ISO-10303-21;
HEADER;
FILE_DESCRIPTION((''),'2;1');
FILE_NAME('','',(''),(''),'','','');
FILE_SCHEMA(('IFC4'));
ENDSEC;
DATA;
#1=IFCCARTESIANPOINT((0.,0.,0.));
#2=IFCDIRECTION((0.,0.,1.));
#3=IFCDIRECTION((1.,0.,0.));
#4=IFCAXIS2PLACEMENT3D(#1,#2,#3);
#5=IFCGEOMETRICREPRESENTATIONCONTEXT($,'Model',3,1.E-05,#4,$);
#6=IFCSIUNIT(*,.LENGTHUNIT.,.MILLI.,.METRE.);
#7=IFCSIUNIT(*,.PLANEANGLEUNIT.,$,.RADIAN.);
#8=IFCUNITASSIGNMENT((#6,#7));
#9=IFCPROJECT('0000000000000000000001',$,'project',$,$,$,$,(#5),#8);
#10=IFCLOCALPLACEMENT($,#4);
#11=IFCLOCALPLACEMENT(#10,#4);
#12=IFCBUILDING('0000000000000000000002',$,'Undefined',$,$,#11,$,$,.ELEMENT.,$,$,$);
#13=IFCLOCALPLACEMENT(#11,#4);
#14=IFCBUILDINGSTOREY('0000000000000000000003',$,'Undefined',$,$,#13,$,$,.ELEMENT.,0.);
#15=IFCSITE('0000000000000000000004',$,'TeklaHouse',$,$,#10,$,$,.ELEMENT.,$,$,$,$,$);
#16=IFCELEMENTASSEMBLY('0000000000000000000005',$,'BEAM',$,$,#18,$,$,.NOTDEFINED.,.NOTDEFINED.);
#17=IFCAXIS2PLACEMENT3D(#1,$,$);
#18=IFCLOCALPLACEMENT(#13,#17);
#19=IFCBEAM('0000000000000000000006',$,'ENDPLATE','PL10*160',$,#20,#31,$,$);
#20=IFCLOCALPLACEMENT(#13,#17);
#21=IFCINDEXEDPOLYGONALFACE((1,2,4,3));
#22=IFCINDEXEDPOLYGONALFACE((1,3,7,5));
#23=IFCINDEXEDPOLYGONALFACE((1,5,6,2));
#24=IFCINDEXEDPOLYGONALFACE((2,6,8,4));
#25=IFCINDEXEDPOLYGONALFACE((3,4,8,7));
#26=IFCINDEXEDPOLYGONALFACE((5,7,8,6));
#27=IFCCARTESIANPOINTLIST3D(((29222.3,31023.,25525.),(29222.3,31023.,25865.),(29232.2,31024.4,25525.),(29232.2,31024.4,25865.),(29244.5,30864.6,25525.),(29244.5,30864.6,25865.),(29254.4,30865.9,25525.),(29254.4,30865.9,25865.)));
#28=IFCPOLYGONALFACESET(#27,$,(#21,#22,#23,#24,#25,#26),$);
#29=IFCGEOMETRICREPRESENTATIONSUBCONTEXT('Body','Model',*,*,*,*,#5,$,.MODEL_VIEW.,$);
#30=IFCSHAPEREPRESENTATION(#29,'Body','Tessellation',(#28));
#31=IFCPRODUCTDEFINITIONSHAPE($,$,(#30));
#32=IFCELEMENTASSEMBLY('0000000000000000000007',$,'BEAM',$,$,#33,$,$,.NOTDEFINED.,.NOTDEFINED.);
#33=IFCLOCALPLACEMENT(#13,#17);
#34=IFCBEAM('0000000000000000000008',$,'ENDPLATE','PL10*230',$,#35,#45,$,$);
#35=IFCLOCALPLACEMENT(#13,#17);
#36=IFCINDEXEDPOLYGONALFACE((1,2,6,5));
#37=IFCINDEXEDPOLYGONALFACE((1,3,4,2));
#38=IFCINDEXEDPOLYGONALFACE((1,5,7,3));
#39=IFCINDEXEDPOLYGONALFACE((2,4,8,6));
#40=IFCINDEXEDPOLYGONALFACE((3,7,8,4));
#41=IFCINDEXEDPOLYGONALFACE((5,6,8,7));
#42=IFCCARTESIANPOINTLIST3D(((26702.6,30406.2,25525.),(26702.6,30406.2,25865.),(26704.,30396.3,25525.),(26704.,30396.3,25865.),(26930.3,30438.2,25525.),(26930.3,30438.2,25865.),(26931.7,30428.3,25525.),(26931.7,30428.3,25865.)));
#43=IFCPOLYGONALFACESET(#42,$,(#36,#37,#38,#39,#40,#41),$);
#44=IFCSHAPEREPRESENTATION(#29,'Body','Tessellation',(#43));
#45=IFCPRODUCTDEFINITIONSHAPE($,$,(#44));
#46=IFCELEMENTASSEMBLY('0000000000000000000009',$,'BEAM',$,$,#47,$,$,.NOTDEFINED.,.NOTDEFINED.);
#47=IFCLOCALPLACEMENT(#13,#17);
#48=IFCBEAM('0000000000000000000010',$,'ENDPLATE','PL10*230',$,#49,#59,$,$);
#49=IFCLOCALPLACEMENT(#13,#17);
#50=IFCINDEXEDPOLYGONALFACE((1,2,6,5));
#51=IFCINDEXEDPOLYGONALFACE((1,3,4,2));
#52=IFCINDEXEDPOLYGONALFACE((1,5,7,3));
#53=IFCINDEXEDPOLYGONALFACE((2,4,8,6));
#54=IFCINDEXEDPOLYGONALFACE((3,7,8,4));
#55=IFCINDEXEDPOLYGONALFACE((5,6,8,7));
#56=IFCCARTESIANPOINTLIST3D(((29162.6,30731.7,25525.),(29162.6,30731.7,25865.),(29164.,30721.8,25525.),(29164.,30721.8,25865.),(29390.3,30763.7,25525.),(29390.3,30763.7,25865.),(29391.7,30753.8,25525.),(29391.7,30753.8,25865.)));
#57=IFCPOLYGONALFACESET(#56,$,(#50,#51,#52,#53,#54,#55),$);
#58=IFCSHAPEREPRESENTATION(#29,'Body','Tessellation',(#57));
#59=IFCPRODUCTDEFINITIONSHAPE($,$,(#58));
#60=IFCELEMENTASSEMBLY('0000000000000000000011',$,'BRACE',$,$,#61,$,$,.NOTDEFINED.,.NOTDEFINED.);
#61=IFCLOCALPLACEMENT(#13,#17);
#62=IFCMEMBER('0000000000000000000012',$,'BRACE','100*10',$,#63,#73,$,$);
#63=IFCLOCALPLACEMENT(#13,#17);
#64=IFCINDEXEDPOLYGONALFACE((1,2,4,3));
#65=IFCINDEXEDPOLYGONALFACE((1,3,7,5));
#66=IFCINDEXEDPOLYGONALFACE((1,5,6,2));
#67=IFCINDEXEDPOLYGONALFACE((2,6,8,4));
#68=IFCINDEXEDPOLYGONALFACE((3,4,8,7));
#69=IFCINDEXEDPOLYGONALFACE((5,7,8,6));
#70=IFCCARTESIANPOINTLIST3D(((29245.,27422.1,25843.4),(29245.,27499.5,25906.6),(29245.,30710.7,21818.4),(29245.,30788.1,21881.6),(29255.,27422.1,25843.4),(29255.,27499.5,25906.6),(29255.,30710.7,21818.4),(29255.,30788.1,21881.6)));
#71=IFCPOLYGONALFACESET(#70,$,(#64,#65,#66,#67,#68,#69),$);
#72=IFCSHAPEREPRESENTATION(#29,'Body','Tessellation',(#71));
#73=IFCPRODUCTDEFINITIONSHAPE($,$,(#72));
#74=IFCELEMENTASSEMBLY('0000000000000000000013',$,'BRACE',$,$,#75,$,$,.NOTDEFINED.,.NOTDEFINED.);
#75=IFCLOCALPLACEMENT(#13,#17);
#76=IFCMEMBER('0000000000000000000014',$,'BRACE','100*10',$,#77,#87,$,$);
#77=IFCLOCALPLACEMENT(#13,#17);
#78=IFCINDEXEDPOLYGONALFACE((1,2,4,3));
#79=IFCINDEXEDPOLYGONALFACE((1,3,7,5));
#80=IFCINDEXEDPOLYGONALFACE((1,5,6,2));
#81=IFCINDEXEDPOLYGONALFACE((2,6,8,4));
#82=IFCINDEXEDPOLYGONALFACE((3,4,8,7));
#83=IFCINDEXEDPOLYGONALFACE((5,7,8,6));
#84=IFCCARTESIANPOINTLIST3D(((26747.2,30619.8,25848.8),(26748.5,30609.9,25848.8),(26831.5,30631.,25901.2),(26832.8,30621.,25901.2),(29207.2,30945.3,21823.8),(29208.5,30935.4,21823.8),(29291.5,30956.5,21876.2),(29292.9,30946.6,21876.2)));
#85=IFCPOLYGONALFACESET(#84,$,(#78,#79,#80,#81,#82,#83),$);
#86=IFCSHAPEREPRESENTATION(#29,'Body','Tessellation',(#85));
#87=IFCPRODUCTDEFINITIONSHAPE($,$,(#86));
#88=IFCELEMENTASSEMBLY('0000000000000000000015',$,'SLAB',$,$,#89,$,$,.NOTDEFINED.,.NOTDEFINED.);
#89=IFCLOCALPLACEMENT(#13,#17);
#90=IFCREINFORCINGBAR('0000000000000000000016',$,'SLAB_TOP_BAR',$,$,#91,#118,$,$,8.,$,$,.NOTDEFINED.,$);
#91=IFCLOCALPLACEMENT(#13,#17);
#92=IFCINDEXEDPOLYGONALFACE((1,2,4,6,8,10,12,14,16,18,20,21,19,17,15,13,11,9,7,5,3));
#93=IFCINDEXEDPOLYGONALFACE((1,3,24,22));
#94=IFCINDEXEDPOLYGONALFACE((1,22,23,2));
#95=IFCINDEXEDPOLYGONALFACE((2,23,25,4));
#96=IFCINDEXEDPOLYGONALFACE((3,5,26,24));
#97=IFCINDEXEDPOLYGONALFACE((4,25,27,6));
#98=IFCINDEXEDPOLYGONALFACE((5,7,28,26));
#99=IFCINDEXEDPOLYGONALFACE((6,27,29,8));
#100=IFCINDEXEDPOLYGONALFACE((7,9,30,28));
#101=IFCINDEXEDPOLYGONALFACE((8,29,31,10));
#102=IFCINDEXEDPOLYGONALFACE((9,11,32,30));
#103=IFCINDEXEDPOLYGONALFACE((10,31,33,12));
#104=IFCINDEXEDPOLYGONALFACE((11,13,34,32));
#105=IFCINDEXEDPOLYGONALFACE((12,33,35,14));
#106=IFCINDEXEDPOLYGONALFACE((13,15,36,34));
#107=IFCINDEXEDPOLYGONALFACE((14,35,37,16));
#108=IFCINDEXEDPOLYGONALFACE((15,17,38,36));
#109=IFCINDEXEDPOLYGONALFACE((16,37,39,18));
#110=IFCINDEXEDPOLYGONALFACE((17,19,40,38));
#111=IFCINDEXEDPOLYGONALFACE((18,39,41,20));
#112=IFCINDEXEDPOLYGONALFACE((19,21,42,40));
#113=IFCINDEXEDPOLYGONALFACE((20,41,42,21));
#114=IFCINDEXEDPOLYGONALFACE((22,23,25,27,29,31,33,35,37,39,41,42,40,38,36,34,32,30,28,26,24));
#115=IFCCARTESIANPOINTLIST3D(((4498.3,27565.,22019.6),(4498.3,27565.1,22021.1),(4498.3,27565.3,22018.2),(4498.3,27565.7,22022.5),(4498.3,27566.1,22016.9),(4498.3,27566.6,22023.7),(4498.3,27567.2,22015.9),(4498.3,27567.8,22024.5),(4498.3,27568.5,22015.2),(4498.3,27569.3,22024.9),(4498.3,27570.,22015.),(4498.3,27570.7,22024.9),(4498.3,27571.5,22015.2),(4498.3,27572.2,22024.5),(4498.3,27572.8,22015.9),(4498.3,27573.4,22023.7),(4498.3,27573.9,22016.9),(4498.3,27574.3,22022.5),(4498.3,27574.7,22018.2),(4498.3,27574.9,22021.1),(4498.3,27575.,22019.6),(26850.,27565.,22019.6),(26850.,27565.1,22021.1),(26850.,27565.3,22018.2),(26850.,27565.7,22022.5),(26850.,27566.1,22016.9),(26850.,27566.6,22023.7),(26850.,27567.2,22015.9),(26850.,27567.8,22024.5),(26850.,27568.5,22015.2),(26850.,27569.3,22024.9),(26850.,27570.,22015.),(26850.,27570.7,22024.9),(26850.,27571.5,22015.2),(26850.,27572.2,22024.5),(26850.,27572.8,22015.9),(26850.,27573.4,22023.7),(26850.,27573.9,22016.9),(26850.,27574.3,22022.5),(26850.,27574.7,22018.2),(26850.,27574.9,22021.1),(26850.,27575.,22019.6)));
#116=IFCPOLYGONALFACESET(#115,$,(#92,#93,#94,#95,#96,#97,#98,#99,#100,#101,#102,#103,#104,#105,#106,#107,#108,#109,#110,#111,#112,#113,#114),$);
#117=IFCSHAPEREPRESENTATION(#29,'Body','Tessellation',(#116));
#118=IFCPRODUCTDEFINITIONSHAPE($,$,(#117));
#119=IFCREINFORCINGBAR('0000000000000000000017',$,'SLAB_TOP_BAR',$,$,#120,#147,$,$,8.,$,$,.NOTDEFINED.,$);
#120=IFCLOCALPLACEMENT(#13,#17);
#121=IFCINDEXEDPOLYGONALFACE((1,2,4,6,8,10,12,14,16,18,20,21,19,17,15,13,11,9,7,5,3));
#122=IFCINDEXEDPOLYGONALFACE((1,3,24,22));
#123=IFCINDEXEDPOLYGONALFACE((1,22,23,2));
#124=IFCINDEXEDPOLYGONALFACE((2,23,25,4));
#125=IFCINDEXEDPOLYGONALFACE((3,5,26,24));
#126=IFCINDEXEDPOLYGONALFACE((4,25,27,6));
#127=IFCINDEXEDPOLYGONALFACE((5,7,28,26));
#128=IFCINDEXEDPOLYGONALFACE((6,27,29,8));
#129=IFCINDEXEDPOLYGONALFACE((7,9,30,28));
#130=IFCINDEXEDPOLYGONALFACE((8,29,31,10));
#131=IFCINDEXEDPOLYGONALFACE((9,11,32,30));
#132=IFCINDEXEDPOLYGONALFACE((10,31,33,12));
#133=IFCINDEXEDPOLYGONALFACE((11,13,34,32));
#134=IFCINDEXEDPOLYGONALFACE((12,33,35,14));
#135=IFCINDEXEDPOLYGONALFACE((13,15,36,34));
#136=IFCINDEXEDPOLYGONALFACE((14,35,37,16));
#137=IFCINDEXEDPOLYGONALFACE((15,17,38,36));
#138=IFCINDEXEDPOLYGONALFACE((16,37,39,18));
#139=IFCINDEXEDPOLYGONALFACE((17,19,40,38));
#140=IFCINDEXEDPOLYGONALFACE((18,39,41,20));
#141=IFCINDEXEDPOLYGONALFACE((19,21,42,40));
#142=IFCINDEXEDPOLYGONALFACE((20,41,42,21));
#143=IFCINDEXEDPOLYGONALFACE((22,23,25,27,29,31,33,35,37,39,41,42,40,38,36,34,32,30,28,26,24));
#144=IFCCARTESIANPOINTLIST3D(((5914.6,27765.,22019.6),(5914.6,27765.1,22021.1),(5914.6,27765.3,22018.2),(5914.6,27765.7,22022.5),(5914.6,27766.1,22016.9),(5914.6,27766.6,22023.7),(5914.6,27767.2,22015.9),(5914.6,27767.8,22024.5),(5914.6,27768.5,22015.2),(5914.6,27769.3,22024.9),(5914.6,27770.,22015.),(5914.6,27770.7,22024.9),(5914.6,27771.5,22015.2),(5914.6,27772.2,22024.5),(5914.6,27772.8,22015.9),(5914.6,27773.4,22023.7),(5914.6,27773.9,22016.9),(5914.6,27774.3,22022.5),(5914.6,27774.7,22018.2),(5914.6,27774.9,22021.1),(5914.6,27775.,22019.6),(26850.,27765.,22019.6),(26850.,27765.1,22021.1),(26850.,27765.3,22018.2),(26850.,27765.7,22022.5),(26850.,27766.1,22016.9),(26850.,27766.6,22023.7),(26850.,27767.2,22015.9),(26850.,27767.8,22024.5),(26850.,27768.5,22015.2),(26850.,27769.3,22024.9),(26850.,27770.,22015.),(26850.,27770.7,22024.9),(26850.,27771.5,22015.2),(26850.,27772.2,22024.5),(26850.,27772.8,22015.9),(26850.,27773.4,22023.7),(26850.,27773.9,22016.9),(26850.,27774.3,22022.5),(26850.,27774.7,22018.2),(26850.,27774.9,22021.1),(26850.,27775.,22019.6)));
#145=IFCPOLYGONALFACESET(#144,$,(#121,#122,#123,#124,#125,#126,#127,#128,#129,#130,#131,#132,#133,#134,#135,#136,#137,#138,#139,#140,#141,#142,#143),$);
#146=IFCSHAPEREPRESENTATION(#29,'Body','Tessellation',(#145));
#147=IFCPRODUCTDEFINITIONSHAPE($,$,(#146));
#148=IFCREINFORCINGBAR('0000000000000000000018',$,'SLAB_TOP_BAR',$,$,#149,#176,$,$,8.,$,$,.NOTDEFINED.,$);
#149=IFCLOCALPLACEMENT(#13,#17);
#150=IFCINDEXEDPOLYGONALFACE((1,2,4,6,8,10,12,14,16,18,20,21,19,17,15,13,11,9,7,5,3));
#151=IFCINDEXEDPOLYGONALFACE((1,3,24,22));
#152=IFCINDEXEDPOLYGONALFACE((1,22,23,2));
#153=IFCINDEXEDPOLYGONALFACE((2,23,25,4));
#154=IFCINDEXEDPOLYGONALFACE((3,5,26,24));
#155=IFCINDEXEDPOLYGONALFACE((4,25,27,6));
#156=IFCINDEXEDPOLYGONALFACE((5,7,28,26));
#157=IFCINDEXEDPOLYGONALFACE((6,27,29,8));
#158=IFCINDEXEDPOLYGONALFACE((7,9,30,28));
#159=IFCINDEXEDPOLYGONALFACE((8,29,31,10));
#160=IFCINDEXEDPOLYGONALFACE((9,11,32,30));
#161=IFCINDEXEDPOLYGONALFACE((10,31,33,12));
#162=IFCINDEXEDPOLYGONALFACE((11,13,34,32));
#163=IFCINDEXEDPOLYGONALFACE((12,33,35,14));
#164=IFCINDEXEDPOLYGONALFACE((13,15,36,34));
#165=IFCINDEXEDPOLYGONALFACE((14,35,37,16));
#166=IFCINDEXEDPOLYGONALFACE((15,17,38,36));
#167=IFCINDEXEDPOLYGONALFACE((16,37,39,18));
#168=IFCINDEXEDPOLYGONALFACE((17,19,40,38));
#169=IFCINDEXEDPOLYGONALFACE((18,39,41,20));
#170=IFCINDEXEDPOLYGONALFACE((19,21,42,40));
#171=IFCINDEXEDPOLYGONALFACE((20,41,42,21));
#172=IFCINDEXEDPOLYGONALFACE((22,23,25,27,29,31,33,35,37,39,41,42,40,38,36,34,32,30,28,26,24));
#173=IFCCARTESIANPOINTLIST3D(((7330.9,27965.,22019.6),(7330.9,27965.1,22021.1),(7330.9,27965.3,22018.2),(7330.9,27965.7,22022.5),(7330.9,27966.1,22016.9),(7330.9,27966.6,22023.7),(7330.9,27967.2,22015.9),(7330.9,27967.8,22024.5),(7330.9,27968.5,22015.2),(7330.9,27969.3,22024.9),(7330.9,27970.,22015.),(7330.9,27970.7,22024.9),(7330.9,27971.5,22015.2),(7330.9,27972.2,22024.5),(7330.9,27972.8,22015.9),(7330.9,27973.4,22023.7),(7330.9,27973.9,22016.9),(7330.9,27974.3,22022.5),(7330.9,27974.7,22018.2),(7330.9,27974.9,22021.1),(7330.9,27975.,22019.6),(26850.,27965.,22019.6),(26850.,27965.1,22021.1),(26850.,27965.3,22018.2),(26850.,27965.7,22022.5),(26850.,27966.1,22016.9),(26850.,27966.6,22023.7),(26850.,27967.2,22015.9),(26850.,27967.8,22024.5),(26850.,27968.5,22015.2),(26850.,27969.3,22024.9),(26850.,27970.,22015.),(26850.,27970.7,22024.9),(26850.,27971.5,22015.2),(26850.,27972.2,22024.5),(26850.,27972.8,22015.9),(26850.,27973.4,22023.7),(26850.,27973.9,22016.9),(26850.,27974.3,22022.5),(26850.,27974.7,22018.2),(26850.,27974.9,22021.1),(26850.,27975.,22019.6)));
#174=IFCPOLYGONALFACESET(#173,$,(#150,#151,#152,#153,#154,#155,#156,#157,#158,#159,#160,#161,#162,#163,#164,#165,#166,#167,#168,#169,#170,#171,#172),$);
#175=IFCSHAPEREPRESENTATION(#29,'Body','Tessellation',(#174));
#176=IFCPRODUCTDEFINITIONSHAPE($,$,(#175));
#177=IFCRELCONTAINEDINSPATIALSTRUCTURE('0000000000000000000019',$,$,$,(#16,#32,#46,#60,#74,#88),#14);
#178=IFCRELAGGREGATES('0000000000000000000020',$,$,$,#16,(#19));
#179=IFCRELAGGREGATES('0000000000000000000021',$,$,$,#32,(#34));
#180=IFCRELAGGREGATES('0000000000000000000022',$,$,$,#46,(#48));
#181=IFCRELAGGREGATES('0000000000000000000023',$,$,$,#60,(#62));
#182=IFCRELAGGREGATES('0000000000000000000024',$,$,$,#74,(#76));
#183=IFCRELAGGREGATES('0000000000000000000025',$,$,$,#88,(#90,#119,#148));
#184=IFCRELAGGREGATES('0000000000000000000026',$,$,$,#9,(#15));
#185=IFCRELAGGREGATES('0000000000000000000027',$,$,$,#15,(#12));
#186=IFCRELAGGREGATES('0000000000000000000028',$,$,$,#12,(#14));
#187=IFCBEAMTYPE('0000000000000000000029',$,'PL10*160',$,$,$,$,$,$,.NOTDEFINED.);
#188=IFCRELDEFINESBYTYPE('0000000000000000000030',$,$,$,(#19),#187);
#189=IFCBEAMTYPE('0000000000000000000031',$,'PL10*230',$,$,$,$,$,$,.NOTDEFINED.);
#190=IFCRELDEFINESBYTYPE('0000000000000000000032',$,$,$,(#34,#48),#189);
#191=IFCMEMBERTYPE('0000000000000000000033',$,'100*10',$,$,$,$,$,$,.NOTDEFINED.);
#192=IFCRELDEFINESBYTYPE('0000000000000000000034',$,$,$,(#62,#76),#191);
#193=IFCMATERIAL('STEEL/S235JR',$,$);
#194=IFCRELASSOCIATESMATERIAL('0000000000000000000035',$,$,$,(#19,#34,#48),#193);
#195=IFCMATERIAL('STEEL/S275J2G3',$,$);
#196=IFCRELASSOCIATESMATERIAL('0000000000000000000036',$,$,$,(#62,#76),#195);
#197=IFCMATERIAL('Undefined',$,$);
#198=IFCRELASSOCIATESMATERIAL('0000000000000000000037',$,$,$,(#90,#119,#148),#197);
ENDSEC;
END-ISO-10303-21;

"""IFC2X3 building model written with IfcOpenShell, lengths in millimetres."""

from ifc_helpers import new_model, entity, si_unit, frame, origin_with_axes, origin_2d_with_axis, place, context, subcontext, project, spatial, rectangle, extrude, source, transform, mapped, material, type_object, element, aggregate, save


model = new_model("IFC2X3")

# Units and contexts
model_context = context("Model", 3, precision=1e-05, world=origin_with_axes())
body_context = subcontext(model_context, "Body", "Model", "MODEL_VIEW")
ifc_project = project(units=[si_unit("LENGTHUNIT", "METRE", prefix="MILLI"), si_unit("PLANEANGLEUNIT", "RADIAN")], contexts=[model_context])

# Site, building, storey
site_placement = place(None, origin_with_axes())
site = spatial("IfcSite", under=ifc_project, at=site_placement, Name="TeklaHouse", CompositionType="ELEMENT")
building_placement = place(site_placement, origin_with_axes())
building = spatial("IfcBuilding", under=site, at=building_placement, Name="Undefined", CompositionType="ELEMENT")
storey_placement = place(building_placement, origin_with_axes())
storey = spatial("IfcBuildingStorey", under=building, at=storey_placement, Name="Undefined", CompositionType="ELEMENT", Elevation=0.0)

# Element assemblies, beams
assembly_1_placement = place(storey_placement, origin_with_axes())
assembly_1 = element("IfcElementAssembly", 1, at=assembly_1_placement, inside=storey, Name="BEAM", AssemblyPlace="NOTDEFINED", PredefinedType="NOTDEFINED")
ifc_material_1 = material(Name="STEEL/S235JR")
beam_type_1 = type_object("IfcBeamType", Name="PL10*160", PredefinedType="NOTDEFINED")
beam_1_placement = place(assembly_1_placement, frame((29238.3, 30944.5, 25525.0), z_axis=(-0.139174, 0.990268, 0.0), x_axis=(0.0, 0.0, 1.0)))
beam_1 = element("IfcBeam", 2, at=beam_1_placement, type_object=beam_type_1, material=ifc_material_1, Name="ENDPLATE", Description="PL10*160", context=body_context, shape_type="SweptSolid", body=[
    extrude(rectangle(XDim=10.0, YDim=160.0, at=origin_2d_with_axis()), frame((340.0, 0.0, 0.0), z_axis=(-1.0, 0.0, 0.0), x_axis=(0.0, -1.0, 0.0)), (0.0, 0.0, 1.0), 340.0),
])
aggregate(assembly_1, [beam_1])
assembly_2_placement = place(storey_placement, origin_with_axes())
assembly_2 = element("IfcElementAssembly", 3, at=assembly_2_placement, inside=storey, Name="BEAM", AssemblyPlace="NOTDEFINED", PredefinedType="NOTDEFINED")
beam_type_2 = type_object("IfcBeamType", Name="PL10*230", PredefinedType="NOTDEFINED")
beam_2_placement = place(assembly_2_placement, frame((26817.1, 30417.2, 25525.0), z_axis=(-0.990268, -0.139173, 0.0), x_axis=(0.0, 0.0, 1.0)))
beam_2 = element("IfcBeam", 4, at=beam_2_placement, type_object=beam_type_2, material=ifc_material_1, Name="ENDPLATE", Description="PL10*230", context=body_context, shape_type="SweptSolid", body=[
    extrude(rectangle(XDim=10.0, YDim=230.0, at=origin_2d_with_axis()), frame((340.0, 0.0, 0.0), z_axis=(-1.0, 0.0, 0.0), x_axis=(0.0, -1.0, 0.0)), (0.0, 0.0, 1.0), 340.0),
])
aggregate(assembly_2, [beam_2])
assembly_3_placement = place(storey_placement, origin_with_axes())
assembly_3 = element("IfcElementAssembly", 5, at=assembly_3_placement, inside=storey, Name="BEAM", AssemblyPlace="NOTDEFINED", PredefinedType="NOTDEFINED")
beam_3_placement = place(assembly_3_placement, frame((29277.1, 30742.8, 25525.0), z_axis=(-0.990268, -0.139173, 0.0), x_axis=(0.0, 0.0, 1.0)))
beam_3 = element("IfcBeam", 6, at=beam_3_placement, type_object=beam_type_2, material=ifc_material_1, Name="ENDPLATE", Description="PL10*230", context=body_context, shape_type="SweptSolid", body=[
    extrude(rectangle(XDim=10.0, YDim=230.0, at=origin_2d_with_axis()), frame((340.0, 0.0, 0.0), z_axis=(-1.0, 0.0, 0.0), x_axis=(0.0, -1.0, 0.0)), (0.0, 0.0, 1.0), 340.0),
])
aggregate(assembly_3, [beam_3])

# Element assemblies, members
assembly_4_placement = place(storey_placement, origin_with_axes())
assembly_4 = element("IfcElementAssembly", 7, at=assembly_4_placement, inside=storey, Name="BRACE", AssemblyPlace="NOTDEFINED", PredefinedType="NOTDEFINED")
ifc_material_2 = material(Name="STEEL/S275J2G3")
member_type = type_object("IfcMemberType", Name="100*10", PredefinedType="NOTDEFINED")
member_1_placement = place(assembly_4_placement, frame((29250.0, 30749.4, 21850.0), z_axis=(0.0, -0.774392, -0.632707), x_axis=(0.0, -0.632707, 0.774392)))
member_1 = element("IfcMember", 8, at=member_1_placement, type_object=member_type, material=ifc_material_2, Name="BRACE", Description="100*10", context=body_context, shape_type="SweptSolid", body=[
    extrude(rectangle(XDim=10.0, YDim=100.0, at=origin_2d_with_axis()), frame((5197.6, 0.0, 0.0), z_axis=(-1.0, 0.0, 0.0), x_axis=(0.0, -1.0, 0.0)), (0.0, 0.0, 1.0), 5197.6),
])
aggregate(assembly_4, [member_1])
assembly_5_placement = place(storey_placement, origin_with_axes())
assembly_5 = element("IfcElementAssembly", 9, at=assembly_5_placement, inside=storey, Name="BRACE", AssemblyPlace="NOTDEFINED", PredefinedType="NOTDEFINED")
member_2_placement = place(assembly_5_placement, frame((29250.0, 30946.0, 21850.0), z_axis=(-0.843874, -0.111676, -0.524791), x_axis=(-0.520255, -0.068849, 0.851231)))
member_2 = element("IfcMember", 10, at=member_2_placement, type_object=member_type, material=ifc_material_2, Name="BRACE", Description="100*10", context=body_context, shape_type="SweptSolid", body=[
    extrude(rectangle(XDim=10.0, YDim=100.0, at=origin_2d_with_axis()), frame((4728.4, 0.0, 0.0), z_axis=(-1.0, 0.0, 0.0), x_axis=(0.0, -1.0, 0.0)), (0.0, 0.0, 1.0), 4728.4),
])
aggregate(assembly_5, [member_2])

# Element assembly, reinforcing bars
assembly_6_placement = place(storey_placement, origin_with_axes())
assembly_6 = element("IfcElementAssembly", 11, at=assembly_6_placement, inside=storey, Name="SLAB", AssemblyPlace="NOTDEFINED", PredefinedType="NOTDEFINED")
ifc_material_3 = material(Name="Undefined")
shared_shape_1 = source(origin_with_axes(), body_context, "Body", "AdvancedSweptSolid", [
    entity("IfcSweptDiskSolid", entity("IfcTrimmedCurve", entity("IfcLine", entity("IfcCartesianPoint", [0.0, 0.0, 0.0]), entity("IfcVector", entity("IfcDirection", [1.0, 0.0, 0.0]), 1.0)), [entity("IfcParameterValue", 0.0)], [entity("IfcParameterValue", 22351.736289)], True, "PARAMETER"), 5.0, None, 0.0, 22351.7),
])
reinforcing_bar_1_placement = place(assembly_6_placement, frame((26850.0, 27570.0, 22020.0), z_axis=(0.0, 0.0, -1.0), x_axis=(-1.0, 0.0, 0.0)))
reinforcing_bar_1 = element("IfcReinforcingBar", 12, at=reinforcing_bar_1_placement, material=ifc_material_3, Name="SLAB_TOP_BAR", BarRole="NOTDEFINED", NominalDiameter=8.0, context=body_context, shape_type="MappedRepresentation", body=[
    mapped(shared_shape_1, transform((0.0, 0.0, 0.0))),
])
shared_shape_2 = source(origin_with_axes(), body_context, "Body", "AdvancedSweptSolid", [
    entity("IfcSweptDiskSolid", entity("IfcTrimmedCurve", entity("IfcLine", entity("IfcCartesianPoint", [0.0, 0.0, 0.0]), entity("IfcVector", entity("IfcDirection", [1.0, 0.0, 0.0]), 1.0)), [entity("IfcParameterValue", 0.0)], [entity("IfcParameterValue", 20935.411553)], True, "PARAMETER"), 5.0, None, 0.0, 20935.4),
])
reinforcing_bar_2_placement = place(assembly_6_placement, frame((26850.0, 27770.0, 22020.0), z_axis=(0.0, 0.0, -1.0), x_axis=(-1.0, 0.0, 0.0)))
reinforcing_bar_2 = element("IfcReinforcingBar", 13, at=reinforcing_bar_2_placement, material=ifc_material_3, Name="SLAB_TOP_BAR", BarRole="NOTDEFINED", NominalDiameter=8.0, context=body_context, shape_type="MappedRepresentation", body=[
    mapped(shared_shape_2, transform((0.0, 0.0, 0.0))),
])
shared_shape_3 = source(origin_with_axes(), body_context, "Body", "AdvancedSweptSolid", [
    entity("IfcSweptDiskSolid", entity("IfcTrimmedCurve", entity("IfcLine", entity("IfcCartesianPoint", [0.0, 0.0, 0.0]), entity("IfcVector", entity("IfcDirection", [1.0, 0.0, 0.0]), 1.0)), [entity("IfcParameterValue", 0.0)], [entity("IfcParameterValue", 19519.086817)], True, "PARAMETER"), 5.0, None, 0.0, 19519.1),
])
reinforcing_bar_3_placement = place(assembly_6_placement, frame((26850.0, 27970.0, 22020.0), z_axis=(0.0, 0.0, -1.0), x_axis=(-1.0, 0.0, 0.0)))
reinforcing_bar_3 = element("IfcReinforcingBar", 14, at=reinforcing_bar_3_placement, material=ifc_material_3, Name="SLAB_TOP_BAR", BarRole="NOTDEFINED", NominalDiameter=8.0, context=body_context, shape_type="MappedRepresentation", body=[
    mapped(shared_shape_3, transform((0.0, 0.0, 0.0))),
])
aggregate(assembly_6, [reinforcing_bar_1, reinforcing_bar_2, reinforcing_bar_3])

save(model, "model.ifc")
